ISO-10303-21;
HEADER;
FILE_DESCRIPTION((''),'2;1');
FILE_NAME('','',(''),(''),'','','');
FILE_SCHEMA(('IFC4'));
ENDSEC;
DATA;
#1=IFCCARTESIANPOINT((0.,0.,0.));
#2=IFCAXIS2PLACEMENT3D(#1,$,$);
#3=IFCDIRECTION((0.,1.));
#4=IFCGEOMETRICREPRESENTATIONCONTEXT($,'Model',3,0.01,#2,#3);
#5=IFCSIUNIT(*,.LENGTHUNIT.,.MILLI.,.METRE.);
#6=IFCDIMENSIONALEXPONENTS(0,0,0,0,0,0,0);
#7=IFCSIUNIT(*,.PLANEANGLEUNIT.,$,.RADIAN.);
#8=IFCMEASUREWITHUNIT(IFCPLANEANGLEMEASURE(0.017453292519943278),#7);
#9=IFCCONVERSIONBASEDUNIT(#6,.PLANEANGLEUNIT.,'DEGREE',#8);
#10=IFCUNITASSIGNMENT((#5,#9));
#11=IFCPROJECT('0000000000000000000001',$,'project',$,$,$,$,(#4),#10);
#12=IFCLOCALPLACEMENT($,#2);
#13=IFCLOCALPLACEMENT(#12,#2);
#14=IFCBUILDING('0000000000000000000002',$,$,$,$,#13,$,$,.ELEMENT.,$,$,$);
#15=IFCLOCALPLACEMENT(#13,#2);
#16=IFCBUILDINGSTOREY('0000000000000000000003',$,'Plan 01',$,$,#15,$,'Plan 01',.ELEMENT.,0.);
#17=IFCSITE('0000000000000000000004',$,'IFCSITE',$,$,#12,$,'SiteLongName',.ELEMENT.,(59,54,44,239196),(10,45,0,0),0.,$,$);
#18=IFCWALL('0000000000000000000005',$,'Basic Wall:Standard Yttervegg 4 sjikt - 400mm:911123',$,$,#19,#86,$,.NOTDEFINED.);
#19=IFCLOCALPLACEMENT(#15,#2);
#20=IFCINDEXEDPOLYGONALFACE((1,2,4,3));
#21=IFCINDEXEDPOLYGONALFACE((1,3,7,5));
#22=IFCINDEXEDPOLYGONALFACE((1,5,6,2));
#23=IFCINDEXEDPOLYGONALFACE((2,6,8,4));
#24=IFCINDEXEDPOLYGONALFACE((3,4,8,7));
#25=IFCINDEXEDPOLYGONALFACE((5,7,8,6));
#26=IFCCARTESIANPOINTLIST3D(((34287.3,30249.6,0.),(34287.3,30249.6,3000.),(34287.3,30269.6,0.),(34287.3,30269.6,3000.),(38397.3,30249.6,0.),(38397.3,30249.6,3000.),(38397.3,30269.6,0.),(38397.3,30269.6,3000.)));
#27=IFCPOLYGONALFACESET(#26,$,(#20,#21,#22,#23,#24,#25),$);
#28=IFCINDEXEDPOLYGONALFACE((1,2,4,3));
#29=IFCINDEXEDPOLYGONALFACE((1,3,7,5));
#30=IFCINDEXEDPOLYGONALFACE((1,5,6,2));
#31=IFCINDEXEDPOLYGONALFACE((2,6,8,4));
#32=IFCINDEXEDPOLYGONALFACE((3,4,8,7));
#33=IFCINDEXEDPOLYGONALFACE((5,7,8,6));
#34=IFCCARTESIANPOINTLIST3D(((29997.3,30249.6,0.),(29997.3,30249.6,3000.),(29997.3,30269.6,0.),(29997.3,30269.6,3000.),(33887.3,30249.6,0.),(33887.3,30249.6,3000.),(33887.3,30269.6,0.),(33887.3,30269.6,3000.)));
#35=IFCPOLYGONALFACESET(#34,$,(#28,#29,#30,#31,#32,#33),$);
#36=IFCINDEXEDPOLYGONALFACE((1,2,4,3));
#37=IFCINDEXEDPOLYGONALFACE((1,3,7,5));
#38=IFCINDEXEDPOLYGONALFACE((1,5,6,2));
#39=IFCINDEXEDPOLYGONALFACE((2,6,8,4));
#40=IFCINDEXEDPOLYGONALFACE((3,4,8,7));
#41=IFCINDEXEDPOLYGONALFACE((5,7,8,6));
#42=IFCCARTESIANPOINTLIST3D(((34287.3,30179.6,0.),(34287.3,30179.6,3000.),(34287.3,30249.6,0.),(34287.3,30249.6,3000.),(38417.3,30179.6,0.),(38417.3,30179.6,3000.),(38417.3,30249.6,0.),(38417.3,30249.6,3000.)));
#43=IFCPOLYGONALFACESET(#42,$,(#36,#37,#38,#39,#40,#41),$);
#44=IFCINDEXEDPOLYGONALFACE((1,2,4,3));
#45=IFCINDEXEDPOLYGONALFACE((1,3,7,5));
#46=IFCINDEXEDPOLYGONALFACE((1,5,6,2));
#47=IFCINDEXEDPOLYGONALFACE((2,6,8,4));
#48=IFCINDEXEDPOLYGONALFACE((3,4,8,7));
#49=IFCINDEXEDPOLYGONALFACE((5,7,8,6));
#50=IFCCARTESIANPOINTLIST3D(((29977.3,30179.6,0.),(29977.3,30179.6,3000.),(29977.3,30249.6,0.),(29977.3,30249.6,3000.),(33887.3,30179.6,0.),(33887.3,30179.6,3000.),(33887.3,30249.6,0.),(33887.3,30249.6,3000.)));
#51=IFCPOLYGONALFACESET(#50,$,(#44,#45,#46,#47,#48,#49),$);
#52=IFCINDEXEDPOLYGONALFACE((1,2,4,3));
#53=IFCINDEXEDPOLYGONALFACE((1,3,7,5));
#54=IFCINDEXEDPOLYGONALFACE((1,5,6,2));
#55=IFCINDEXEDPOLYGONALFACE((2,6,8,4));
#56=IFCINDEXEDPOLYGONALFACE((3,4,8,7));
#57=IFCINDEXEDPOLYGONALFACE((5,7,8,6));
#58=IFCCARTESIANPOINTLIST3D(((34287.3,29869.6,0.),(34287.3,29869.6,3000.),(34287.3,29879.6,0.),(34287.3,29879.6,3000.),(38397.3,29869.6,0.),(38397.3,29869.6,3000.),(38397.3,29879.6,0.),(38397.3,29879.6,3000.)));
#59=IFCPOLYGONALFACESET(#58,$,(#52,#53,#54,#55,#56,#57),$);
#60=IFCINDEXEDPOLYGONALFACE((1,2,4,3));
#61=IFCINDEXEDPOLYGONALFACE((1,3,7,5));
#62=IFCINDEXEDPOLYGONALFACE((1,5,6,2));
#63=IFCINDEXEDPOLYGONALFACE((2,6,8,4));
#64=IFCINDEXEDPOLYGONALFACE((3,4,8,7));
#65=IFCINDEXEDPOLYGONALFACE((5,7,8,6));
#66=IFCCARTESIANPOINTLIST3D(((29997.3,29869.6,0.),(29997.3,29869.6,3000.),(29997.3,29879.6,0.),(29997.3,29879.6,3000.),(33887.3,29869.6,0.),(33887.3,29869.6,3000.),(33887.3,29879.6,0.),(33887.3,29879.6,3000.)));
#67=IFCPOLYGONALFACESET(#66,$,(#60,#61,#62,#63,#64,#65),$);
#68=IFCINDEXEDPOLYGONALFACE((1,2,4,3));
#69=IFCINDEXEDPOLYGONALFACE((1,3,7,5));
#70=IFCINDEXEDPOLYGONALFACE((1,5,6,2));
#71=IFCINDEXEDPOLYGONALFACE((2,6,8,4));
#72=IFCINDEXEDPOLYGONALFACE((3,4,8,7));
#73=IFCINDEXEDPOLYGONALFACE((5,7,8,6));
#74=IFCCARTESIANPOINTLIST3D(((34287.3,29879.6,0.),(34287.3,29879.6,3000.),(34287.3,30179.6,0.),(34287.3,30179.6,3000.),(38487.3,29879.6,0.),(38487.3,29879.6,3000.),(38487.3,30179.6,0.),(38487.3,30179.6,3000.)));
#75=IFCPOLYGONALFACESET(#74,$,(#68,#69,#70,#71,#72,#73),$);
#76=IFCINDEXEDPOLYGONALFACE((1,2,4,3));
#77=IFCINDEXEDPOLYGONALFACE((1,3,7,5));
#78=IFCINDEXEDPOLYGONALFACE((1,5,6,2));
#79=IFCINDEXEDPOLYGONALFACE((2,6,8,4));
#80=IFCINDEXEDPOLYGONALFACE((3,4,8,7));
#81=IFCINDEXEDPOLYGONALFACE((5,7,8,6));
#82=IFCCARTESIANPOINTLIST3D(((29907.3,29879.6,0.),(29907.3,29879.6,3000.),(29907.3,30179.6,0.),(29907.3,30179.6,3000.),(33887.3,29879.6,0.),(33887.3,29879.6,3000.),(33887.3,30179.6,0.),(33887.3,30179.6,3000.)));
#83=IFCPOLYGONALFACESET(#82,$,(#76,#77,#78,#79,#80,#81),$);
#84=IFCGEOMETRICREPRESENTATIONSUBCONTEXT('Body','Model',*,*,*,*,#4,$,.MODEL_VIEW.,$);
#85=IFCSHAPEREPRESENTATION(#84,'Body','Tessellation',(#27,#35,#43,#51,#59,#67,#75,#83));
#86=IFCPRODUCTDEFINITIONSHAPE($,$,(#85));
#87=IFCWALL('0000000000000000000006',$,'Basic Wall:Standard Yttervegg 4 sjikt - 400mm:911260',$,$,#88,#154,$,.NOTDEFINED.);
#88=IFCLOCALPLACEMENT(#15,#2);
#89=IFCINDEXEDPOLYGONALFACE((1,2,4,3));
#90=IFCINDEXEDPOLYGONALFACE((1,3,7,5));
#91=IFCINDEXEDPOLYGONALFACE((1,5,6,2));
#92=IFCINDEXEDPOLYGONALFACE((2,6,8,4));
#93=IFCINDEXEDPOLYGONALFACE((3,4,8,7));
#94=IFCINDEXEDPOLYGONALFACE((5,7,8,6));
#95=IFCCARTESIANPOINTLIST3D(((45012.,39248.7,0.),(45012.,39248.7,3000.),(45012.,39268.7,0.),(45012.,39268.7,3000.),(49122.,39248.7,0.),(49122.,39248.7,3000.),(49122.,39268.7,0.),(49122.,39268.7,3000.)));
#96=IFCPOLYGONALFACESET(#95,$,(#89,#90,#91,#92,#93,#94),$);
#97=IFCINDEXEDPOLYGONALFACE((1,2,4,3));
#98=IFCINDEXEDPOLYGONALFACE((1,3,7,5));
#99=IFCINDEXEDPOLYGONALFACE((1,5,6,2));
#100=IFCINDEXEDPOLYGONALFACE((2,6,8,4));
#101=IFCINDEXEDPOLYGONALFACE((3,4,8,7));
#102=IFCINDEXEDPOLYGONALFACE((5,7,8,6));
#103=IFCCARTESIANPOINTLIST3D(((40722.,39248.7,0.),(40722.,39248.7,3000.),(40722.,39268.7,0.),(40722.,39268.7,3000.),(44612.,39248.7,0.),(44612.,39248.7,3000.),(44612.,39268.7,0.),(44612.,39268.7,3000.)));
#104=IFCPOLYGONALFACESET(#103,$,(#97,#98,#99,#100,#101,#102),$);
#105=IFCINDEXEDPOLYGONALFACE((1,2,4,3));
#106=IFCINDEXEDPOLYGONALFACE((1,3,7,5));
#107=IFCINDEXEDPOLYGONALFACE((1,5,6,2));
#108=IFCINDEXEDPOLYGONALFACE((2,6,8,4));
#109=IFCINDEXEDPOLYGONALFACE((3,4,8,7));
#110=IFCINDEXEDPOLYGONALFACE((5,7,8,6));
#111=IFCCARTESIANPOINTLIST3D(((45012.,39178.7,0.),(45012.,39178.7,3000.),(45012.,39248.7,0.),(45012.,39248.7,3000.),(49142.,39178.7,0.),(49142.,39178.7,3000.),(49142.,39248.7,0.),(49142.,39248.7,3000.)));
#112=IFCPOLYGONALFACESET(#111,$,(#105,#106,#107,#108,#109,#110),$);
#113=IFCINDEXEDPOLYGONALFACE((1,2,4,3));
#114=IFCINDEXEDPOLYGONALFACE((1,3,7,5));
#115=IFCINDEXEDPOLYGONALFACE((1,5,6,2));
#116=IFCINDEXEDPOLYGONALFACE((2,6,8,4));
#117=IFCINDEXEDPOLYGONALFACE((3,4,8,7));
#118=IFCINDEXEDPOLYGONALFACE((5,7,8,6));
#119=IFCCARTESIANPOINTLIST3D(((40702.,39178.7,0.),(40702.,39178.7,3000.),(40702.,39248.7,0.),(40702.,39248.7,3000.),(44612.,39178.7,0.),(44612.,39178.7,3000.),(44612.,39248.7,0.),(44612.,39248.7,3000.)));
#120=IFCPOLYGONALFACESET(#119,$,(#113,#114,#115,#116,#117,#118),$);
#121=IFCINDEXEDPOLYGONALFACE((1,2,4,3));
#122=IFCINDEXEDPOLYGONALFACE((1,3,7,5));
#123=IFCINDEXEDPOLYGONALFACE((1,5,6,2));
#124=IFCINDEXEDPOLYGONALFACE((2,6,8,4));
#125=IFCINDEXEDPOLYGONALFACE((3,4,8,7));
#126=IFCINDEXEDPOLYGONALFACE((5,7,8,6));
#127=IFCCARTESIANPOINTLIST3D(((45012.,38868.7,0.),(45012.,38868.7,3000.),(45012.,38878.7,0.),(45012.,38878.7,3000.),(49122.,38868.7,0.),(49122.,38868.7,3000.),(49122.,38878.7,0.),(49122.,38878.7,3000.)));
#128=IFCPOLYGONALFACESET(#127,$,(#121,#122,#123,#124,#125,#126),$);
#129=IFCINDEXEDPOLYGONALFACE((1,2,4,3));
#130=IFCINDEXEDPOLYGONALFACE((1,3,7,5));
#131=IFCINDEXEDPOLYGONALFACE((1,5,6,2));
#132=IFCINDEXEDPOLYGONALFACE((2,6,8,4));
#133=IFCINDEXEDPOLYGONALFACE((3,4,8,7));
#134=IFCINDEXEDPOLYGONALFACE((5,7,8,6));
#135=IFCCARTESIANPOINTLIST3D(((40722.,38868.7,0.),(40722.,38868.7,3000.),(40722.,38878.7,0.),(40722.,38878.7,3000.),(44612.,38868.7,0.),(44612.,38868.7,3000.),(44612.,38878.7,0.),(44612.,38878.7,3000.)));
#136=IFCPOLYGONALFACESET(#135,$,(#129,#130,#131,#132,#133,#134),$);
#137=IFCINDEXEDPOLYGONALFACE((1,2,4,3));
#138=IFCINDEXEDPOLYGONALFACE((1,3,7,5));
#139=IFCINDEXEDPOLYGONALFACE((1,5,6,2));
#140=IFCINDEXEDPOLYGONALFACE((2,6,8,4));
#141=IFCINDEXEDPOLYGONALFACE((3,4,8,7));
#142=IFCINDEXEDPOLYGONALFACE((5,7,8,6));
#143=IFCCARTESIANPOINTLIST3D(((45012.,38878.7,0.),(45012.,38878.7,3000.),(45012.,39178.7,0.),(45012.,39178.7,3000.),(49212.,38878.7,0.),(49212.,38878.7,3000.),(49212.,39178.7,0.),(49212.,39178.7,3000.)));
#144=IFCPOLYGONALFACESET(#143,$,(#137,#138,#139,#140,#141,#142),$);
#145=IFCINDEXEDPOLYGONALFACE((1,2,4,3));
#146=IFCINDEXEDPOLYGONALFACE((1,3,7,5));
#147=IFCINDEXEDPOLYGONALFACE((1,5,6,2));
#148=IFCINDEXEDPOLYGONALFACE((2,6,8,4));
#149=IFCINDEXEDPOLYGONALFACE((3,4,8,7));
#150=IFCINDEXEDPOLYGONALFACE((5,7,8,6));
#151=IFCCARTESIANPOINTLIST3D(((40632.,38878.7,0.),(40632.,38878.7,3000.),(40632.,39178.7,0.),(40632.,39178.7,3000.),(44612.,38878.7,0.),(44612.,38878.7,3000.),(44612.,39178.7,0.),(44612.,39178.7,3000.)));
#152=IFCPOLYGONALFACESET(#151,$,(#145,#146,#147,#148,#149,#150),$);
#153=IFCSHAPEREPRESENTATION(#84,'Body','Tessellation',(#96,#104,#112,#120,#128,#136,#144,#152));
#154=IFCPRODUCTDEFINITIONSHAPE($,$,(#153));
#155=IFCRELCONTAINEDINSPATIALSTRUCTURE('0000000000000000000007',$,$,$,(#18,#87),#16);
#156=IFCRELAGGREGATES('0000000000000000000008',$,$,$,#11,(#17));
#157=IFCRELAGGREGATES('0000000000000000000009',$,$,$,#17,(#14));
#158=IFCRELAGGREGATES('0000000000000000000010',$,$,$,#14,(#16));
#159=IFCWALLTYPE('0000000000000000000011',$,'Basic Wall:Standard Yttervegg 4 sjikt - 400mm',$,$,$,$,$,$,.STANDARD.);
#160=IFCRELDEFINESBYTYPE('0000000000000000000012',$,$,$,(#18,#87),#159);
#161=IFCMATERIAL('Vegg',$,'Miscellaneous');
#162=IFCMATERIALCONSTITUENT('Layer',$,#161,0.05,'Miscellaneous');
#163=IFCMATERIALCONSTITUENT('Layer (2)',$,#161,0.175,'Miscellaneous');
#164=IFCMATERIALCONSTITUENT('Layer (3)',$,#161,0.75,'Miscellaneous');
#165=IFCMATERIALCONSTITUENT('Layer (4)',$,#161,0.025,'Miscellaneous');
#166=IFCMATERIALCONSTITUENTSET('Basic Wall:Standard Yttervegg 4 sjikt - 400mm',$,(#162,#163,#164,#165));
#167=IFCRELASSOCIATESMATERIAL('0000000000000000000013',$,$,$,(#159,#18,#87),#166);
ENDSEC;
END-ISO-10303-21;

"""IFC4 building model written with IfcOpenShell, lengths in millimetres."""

from ifc_helpers import new_model, entity, si_unit, converted_unit, direction, frame, origin, place, context, subcontext, project, spatial, indexed_curve, outline, extrude, material, constituent, constituent_set, type_object, element, save


model = new_model("IFC4")

# Units and contexts
model_context = context("Model", 3, precision=0.01, world=origin(), true_north=direction((0.0, 1.0)))
body_context = subcontext(model_context, "Body", "Model", "MODEL_VIEW")
ifc_project = project(units=[si_unit("LENGTHUNIT", "METRE", prefix="MILLI"), converted_unit("PLANEANGLEUNIT", "DEGREE", entity("IfcPlaneAngleMeasure", 0.017453292519943278), si_unit("PLANEANGLEUNIT", "RADIAN"), dimensions=[0, 0, 0, 0, 0, 0, 0])], contexts=[model_context])

# Site, building, storey
site_placement = place(None, origin())
site = spatial("IfcSite", under=ifc_project, at=site_placement, Name="IFCSITE", LongName="SiteLongName", CompositionType="ELEMENT", RefLatitude=(59, 54, 44, 239196), RefLongitude=(10, 45, 0, 0), RefElevation=0.0)
building_placement = place(site_placement, origin())
building = spatial("IfcBuilding", under=site, at=building_placement, CompositionType="ELEMENT")
storey_placement = place(building_placement, origin())
storey = spatial("IfcBuildingStorey", under=building, at=storey_placement, Name="Plan 01", LongName="Plan 01", CompositionType="ELEMENT", Elevation=0.0)

# Walls
ifc_material_1 = material(Name="Vegg", Category="Miscellaneous")
ifc_constituent_1 = constituent(ifc_material_1, Name="Layer", Category="Miscellaneous", fraction=0.05)
ifc_constituent_2 = constituent(ifc_material_1, Name="Layer (2)", Category="Miscellaneous", fraction=0.175)
ifc_constituent_3 = constituent(ifc_material_1, Name="Layer (3)", Category="Miscellaneous", fraction=0.75)
ifc_constituent_4 = constituent(ifc_material_1, Name="Layer (4)", Category="Miscellaneous", fraction=0.025)
ifc_constituent_set_1 = constituent_set(constituents=[ifc_constituent_1, ifc_constituent_2, ifc_constituent_3, ifc_constituent_4], Name="Basic Wall:Standard Yttervegg 4 sjikt - 400mm")
wall_type = type_object("IfcWallType", Name="Basic Wall:Standard Yttervegg 4 sjikt - 400mm", PredefinedType="STANDARD", material=ifc_constituent_set_1)
wall_1_placement = place(storey_placement, frame((29997.3, 30069.6, 0.0)))
element("IfcWall", 1, at=wall_1_placement, inside=storey, type_object=wall_type, material=ifc_constituent_set_1, Name="Basic Wall:Standard Yttervegg 4 sjikt - 400mm:911123", PredefinedType="NOTDEFINED", context=body_context, shape_type="SweptSolid", body=[
    extrude(outline(indexed_curve([(-10.0, -2055.0), (10.0, -2055.0), (10.0, 2055.0), (-10.0, 2055.0), (-10.0, -2055.0)], self_intersect=False)), frame((6345.0, 190.0, 0.0), z_axis=(0.0, 0.0, 1.0), x_axis=(0.0, -1.0, 0.0)), (0.0, 0.0, 1.0), 3000.0),
    extrude(outline(indexed_curve([(-10.0, -1945.0), (10.0, -1945.0), (10.0, 1945.0), (-10.0, 1945.0), (-10.0, -1945.0)], self_intersect=False)), frame((1945.0, 190.0, 0.0), z_axis=(0.0, 0.0, 1.0), x_axis=(0.0, -1.0, 0.0)), (0.0, 0.0, 1.0), 3000.0),
    extrude(outline(indexed_curve([(-2065.0, -35.0), (2065.0, -35.0), (2065.0, 35.0), (-2065.0, 35.0), (-2065.0, -35.0)], self_intersect=False)), frame((6355.0, 145.0, 0.0), z_axis=(0.0, 0.0, 1.0), x_axis=(-1.0, 0.0, 0.0)), (0.0, 0.0, 1.0), 3000.0),
    extrude(outline(indexed_curve([(-1955.0, -35.0), (1955.0, -35.0), (1955.0, 35.0), (-1955.0, 35.0), (-1955.0, -35.0)], self_intersect=False)), frame((1935.0, 145.0, 0.0)), (0.0, 0.0, 1.0), 3000.0),
    extrude(outline(indexed_curve([(-5.0, -2055.0), (5.0, -2055.0), (5.0, 2055.0), (-5.0, 2055.0), (-5.0, -2055.0)], self_intersect=False)), frame((6345.0, -195.0, 0.0), z_axis=(0.0, 0.0, 1.0), x_axis=(0.0, 1.0, 0.0)), (0.0, 0.0, 1.0), 3000.0),
    extrude(outline(indexed_curve([(-5.0, -1945.0), (5.0, -1945.0), (5.0, 1945.0), (-5.0, 1945.0), (-5.0, -1945.0)], self_intersect=False)), frame((1945.0, -195.0, 0.0), z_axis=(0.0, 0.0, 1.0), x_axis=(0.0, 1.0, 0.0)), (0.0, 0.0, 1.0), 3000.0),
    extrude(outline(indexed_curve([(-2100.0, -150.0), (2100.0, -150.0), (2100.0, 150.0), (-2100.0, 150.0), (-2100.0, -150.0)], self_intersect=False)), frame((6390.0, -40.0, 0.0), z_axis=(0.0, 0.0, 1.0), x_axis=(-1.0, 0.0, 0.0)), (0.0, 0.0, 1.0), 3000.0),
    extrude(outline(indexed_curve([(-1990.0, -150.0), (1990.0, -150.0), (1990.0, 150.0), (-1990.0, 150.0), (-1990.0, -150.0)], self_intersect=False)), frame((1900.0, -40.0, 0.0)), (0.0, 0.0, 1.0), 3000.0),
])
wall_2_placement = place(storey_placement, frame((40722.0, 39068.7, 0.0)))
element("IfcWall", 2, at=wall_2_placement, inside=storey, type_object=wall_type, material=ifc_constituent_set_1, Name="Basic Wall:Standard Yttervegg 4 sjikt - 400mm:911260", PredefinedType="NOTDEFINED", context=body_context, shape_type="SweptSolid", body=[
    extrude(outline(indexed_curve([(-10.0, -2055.0), (10.0, -2055.0), (10.0, 2055.0), (-10.0, 2055.0), (-10.0, -2055.0)], self_intersect=False)), frame((6345.0, 190.0, 0.0), z_axis=(0.0, 0.0, 1.0), x_axis=(0.0, -1.0, 0.0)), (0.0, 0.0, 1.0), 3000.0),
    extrude(outline(indexed_curve([(-10.0, -1945.0), (10.0, -1945.0), (10.0, 1945.0), (-10.0, 1945.0), (-10.0, -1945.0)], self_intersect=False)), frame((1945.0, 190.0, 0.0), z_axis=(0.0, 0.0, 1.0), x_axis=(0.0, -1.0, 0.0)), (0.0, 0.0, 1.0), 3000.0),
    extrude(outline(indexed_curve([(-2065.0, -35.0), (2065.0, -35.0), (2065.0, 35.0), (-2065.0, 35.0), (-2065.0, -35.0)], self_intersect=False)), frame((6355.0, 145.0, 0.0), z_axis=(0.0, 0.0, 1.0), x_axis=(-1.0, 0.0, 0.0)), (0.0, 0.0, 1.0), 3000.0),
    extrude(outline(indexed_curve([(-1955.0, -35.0), (1955.0, -35.0), (1955.0, 35.0), (-1955.0, 35.0), (-1955.0, -35.0)], self_intersect=False)), frame((1935.0, 145.0, 0.0)), (0.0, 0.0, 1.0), 3000.0),
    extrude(outline(indexed_curve([(-5.0, -2055.0), (5.0, -2055.0), (5.0, 2055.0), (-5.0, 2055.0), (-5.0, -2055.0)], self_intersect=False)), frame((6345.0, -195.0, 0.0), z_axis=(0.0, 0.0, 1.0), x_axis=(0.0, 1.0, 0.0)), (0.0, 0.0, 1.0), 3000.0),
    extrude(outline(indexed_curve([(-5.0, -1945.0), (5.0, -1945.0), (5.0, 1945.0), (-5.0, 1945.0), (-5.0, -1945.0)], self_intersect=False)), frame((1945.0, -195.0, 0.0), z_axis=(0.0, 0.0, 1.0), x_axis=(0.0, 1.0, 0.0)), (0.0, 0.0, 1.0), 3000.0),
    extrude(outline(indexed_curve([(-2100.0, -150.0), (2100.0, -150.0), (2100.0, 150.0), (-2100.0, 150.0), (-2100.0, -150.0)], self_intersect=False)), frame((6390.0, -40.0, 0.0), z_axis=(0.0, 0.0, 1.0), x_axis=(-1.0, 0.0, 0.0)), (0.0, 0.0, 1.0), 3000.0),
    extrude(outline(indexed_curve([(-1990.0, -150.0), (1990.0, -150.0), (1990.0, 150.0), (-1990.0, 150.0), (-1990.0, -150.0)], self_intersect=False)), frame((1900.0, -40.0, 0.0)), (0.0, 0.0, 1.0), 3000.0),
])

save(model, "model.ifc")
